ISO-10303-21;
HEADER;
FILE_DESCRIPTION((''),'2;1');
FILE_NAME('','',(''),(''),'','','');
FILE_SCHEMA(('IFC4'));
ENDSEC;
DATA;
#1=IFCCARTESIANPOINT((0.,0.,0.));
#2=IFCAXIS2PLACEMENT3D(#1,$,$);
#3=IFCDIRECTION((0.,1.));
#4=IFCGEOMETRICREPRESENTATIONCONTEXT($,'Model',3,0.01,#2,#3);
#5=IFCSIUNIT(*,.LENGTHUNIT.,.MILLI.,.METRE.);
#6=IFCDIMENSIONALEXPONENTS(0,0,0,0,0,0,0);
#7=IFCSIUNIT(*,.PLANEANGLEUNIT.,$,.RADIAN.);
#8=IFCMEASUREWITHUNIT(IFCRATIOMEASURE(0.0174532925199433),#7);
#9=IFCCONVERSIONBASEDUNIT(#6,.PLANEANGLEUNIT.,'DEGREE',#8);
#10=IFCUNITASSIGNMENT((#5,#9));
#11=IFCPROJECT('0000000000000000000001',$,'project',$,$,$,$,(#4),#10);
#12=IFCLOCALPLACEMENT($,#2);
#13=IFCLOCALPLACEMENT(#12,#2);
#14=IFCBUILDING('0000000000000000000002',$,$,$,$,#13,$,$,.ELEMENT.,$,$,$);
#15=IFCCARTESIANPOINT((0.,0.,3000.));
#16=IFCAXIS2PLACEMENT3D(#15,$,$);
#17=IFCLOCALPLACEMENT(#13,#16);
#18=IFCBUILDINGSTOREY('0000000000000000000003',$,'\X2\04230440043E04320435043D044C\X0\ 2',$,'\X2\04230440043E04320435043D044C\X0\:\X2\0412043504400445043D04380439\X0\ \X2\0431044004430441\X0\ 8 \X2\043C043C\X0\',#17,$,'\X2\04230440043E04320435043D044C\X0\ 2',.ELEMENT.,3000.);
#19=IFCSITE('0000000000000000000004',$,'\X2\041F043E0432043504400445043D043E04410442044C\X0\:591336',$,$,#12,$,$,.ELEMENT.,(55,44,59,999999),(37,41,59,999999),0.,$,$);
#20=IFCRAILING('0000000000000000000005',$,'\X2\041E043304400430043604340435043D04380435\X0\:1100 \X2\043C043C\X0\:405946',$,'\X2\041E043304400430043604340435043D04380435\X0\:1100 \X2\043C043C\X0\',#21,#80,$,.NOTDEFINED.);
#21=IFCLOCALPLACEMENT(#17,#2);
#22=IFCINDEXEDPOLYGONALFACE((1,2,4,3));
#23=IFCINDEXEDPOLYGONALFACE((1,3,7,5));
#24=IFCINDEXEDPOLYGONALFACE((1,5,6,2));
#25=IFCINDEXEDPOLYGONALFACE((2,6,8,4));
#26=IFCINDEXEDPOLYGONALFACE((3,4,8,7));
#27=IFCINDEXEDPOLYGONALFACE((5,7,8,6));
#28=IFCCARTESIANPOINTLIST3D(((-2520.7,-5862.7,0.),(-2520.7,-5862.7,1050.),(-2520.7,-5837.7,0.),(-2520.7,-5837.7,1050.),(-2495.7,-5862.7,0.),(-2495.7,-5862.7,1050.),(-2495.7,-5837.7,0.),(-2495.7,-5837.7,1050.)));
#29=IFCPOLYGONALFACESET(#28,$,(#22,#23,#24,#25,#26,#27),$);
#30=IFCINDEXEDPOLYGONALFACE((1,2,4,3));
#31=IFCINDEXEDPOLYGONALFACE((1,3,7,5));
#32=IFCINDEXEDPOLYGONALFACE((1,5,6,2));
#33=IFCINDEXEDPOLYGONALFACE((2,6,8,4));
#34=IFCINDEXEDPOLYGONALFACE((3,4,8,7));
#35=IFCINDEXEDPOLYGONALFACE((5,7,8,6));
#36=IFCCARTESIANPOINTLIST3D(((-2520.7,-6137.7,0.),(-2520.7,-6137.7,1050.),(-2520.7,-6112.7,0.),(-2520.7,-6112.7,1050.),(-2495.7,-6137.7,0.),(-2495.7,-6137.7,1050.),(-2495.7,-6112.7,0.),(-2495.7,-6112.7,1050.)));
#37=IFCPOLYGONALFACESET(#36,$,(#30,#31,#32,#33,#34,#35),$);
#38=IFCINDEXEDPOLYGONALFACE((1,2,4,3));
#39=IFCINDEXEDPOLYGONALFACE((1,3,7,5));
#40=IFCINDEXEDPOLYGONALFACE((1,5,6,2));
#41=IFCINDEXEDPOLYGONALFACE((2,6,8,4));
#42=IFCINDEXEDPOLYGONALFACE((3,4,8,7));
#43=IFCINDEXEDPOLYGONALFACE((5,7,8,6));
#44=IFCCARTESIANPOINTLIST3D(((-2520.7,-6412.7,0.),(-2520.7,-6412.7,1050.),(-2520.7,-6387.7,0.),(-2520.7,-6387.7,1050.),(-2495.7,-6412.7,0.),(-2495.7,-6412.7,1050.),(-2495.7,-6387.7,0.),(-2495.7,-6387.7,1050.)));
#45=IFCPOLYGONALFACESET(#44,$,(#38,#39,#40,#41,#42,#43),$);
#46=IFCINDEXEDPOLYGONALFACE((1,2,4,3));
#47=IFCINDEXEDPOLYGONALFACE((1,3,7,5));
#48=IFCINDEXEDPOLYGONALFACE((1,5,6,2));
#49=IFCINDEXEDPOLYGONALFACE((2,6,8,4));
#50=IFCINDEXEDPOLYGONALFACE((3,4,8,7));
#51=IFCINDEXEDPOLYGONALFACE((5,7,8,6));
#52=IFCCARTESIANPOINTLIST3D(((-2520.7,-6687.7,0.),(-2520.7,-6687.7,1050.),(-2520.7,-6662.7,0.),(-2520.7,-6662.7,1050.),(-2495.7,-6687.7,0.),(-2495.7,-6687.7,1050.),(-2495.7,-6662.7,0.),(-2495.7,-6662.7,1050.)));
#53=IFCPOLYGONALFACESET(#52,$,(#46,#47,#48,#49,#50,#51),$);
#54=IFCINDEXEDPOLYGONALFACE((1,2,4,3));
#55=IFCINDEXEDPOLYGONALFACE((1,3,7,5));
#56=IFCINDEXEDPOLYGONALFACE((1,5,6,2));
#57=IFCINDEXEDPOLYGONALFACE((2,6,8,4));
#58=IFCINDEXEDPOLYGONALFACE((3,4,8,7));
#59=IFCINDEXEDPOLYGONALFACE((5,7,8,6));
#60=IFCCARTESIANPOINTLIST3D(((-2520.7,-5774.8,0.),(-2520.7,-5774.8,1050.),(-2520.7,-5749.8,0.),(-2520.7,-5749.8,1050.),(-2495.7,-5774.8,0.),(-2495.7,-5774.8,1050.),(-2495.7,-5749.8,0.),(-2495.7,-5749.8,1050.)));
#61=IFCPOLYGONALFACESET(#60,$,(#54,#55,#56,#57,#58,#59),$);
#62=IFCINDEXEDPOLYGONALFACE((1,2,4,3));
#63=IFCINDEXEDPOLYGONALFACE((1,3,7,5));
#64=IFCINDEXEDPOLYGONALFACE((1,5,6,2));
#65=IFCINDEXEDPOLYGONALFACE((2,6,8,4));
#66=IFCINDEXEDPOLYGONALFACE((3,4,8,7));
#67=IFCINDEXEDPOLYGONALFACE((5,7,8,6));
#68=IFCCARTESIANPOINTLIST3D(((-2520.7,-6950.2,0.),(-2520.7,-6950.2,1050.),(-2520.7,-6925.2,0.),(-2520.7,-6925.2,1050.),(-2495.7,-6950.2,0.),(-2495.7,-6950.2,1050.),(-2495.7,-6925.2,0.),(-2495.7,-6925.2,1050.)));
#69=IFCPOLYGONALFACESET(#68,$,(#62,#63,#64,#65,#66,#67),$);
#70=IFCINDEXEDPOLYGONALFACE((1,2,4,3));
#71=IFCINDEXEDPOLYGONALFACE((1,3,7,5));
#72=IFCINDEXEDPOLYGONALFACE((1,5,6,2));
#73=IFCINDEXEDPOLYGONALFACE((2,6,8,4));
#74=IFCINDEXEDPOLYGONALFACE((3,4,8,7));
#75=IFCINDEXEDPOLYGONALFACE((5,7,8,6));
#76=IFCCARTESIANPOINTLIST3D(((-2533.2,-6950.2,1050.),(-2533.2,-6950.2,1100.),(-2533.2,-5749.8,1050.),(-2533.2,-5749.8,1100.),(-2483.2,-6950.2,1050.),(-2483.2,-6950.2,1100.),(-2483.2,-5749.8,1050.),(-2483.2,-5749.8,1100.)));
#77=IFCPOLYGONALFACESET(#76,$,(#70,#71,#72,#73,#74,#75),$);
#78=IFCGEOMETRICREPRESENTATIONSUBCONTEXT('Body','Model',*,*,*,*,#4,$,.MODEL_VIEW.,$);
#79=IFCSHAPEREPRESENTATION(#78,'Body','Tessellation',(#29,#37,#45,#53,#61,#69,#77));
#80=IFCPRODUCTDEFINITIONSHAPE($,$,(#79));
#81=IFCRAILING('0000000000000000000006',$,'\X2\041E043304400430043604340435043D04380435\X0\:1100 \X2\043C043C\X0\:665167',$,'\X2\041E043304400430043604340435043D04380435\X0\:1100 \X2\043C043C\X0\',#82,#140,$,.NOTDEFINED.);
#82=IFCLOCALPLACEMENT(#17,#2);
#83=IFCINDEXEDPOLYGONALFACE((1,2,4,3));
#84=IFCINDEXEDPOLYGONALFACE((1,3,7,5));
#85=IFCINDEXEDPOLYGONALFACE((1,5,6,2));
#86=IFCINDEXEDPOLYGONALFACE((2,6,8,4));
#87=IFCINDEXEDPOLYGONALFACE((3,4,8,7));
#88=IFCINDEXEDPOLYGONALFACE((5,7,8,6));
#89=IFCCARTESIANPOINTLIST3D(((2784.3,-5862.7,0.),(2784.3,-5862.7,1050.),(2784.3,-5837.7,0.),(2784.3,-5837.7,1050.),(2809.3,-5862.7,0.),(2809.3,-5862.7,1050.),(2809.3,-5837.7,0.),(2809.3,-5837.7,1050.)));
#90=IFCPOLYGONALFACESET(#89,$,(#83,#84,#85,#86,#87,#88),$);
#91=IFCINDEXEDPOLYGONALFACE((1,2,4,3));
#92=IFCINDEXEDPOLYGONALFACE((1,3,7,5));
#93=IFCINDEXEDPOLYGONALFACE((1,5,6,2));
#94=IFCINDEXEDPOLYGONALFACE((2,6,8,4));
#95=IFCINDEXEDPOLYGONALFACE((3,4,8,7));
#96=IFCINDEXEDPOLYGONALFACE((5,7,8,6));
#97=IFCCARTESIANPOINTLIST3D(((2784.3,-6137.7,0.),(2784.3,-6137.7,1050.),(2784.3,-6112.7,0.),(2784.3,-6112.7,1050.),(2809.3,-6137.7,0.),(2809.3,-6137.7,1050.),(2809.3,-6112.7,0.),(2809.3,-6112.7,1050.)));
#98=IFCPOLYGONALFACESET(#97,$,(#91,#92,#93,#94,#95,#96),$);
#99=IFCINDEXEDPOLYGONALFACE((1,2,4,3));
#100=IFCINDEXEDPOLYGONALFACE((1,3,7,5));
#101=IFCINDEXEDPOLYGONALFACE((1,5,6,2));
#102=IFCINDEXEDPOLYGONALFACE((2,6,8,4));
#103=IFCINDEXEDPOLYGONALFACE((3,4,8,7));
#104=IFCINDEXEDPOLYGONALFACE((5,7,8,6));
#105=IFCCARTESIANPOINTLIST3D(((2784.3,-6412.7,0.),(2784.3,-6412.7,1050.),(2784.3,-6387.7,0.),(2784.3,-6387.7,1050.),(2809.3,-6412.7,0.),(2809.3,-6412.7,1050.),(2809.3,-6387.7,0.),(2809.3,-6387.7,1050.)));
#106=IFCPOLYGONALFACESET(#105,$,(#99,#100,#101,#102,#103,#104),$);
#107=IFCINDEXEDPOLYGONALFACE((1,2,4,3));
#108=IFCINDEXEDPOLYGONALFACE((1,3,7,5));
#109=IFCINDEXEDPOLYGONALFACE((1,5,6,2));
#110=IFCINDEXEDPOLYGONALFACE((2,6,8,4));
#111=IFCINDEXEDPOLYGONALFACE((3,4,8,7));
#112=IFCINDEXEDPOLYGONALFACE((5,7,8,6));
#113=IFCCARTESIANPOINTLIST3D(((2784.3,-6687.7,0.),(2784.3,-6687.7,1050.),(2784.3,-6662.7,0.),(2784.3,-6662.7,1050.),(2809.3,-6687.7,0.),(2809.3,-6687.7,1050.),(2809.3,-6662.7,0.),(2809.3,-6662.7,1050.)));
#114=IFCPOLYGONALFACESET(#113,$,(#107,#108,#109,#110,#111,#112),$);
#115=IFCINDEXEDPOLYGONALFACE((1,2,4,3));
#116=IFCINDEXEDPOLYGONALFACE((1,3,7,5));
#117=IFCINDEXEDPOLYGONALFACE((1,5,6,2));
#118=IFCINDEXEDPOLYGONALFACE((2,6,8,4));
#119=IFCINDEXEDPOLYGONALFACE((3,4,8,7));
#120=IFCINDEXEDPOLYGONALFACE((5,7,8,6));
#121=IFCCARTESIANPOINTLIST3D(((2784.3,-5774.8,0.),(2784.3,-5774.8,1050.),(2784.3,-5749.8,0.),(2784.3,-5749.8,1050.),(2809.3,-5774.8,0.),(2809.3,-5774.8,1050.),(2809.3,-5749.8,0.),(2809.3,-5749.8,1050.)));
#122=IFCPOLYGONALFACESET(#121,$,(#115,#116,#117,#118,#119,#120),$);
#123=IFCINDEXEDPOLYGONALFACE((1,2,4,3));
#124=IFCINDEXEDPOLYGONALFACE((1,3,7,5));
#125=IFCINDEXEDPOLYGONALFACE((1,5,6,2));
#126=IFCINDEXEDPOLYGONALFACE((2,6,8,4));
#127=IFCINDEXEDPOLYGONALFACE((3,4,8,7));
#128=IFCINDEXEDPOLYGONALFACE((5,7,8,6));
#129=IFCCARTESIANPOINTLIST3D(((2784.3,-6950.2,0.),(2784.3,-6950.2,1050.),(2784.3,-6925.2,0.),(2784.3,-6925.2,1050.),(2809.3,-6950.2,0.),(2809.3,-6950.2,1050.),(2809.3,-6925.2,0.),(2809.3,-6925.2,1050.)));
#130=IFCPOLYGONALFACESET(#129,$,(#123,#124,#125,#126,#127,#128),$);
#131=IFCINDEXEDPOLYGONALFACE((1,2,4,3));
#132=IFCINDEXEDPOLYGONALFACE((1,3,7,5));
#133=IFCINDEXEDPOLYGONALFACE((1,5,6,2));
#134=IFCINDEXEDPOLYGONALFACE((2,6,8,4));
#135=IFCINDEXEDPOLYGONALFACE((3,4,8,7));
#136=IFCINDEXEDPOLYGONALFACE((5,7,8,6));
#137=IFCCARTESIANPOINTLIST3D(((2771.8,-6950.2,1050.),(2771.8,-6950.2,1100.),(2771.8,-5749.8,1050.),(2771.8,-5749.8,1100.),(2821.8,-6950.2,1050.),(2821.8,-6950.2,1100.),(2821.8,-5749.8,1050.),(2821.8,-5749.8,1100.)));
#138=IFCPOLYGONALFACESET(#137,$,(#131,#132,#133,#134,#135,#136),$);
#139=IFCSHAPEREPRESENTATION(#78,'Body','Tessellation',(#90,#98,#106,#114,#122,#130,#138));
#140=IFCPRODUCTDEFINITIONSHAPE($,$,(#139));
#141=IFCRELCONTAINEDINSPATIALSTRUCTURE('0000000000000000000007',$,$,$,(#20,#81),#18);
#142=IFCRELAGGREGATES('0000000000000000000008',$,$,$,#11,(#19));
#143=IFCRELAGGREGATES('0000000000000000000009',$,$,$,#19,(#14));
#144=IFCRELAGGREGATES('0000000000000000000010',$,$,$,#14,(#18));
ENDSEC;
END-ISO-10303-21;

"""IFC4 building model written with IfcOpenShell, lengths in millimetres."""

from ifc_helpers import new_model, entity, si_unit, converted_unit, direction, frame, origin, place, context, subcontext, project, spatial, indexed_curve, outline, extrude, element, save


model = new_model("IFC4")

# Units and contexts
model_context = context("Model", 3, precision=0.01, world=origin(), true_north=direction((0.0, 1.0)))
body_context = subcontext(model_context, "Body", "Model", "MODEL_VIEW")
ifc_project = project(units=[si_unit("LENGTHUNIT", "METRE", prefix="MILLI"), converted_unit("PLANEANGLEUNIT", "DEGREE", entity("IfcRatioMeasure", 0.0174532925199433), si_unit("PLANEANGLEUNIT", "RADIAN"), dimensions=[0, 0, 0, 0, 0, 0, 0])], contexts=[model_context])

# Site, building, storey
site_placement = place(None, origin())
site = spatial("IfcSite", under=ifc_project, at=site_placement, Name="Поверхность:591336", CompositionType="ELEMENT", RefLatitude=(55, 44, 59, 999999), RefLongitude=(37, 41, 59, 999999), RefElevation=0.0)
building_placement = place(site_placement, origin())
building = spatial("IfcBuilding", under=site, at=building_placement, CompositionType="ELEMENT")
storey_placement = place(building_placement, frame((0.0, 0.0, 3000.0)))
storey = spatial("IfcBuildingStorey", under=building, at=storey_placement, Name="Уровень 2", ObjectType="Уровень:Верхний брус 8 мм", LongName="Уровень 2", CompositionType="ELEMENT", Elevation=3000.0)

# Railings
railing_1_placement = place(storey_placement, origin())
element("IfcRailing", 1, at=railing_1_placement, inside=storey, Name="Ограждение:1100 мм:405946", ObjectType="Ограждение:1100 мм", PredefinedType="NOTDEFINED", context=body_context, shape_type="SweptSolid", body=[
    extrude(outline(indexed_curve([(-12.5, -12.5), (12.5, -12.5), (12.5, 12.5), (-12.5, 12.5), (-12.5, -12.5)], self_intersect=False)), frame((-2508.2, -5850.2, 0.0), z_axis=(0.0, 0.0, 1.0), x_axis=(0.0, 1.0, 0.0)), (0.0, 0.0, 1.0), 1050.0),
    extrude(outline(indexed_curve([(-12.5, -12.5), (12.5, -12.5), (12.5, 12.5), (-12.5, 12.5), (-12.5, -12.5)], self_intersect=False)), frame((-2508.2, -6125.2, 0.0), z_axis=(0.0, 0.0, 1.0), x_axis=(0.0, 1.0, 0.0)), (0.0, 0.0, 1.0), 1050.0),
    extrude(outline(indexed_curve([(-12.5, -12.5), (12.5, -12.5), (12.5, 12.5), (-12.5, 12.5), (-12.5, -12.5)], self_intersect=False)), frame((-2508.2, -6400.2, 0.0), z_axis=(0.0, 0.0, 1.0), x_axis=(0.0, 1.0, 0.0)), (0.0, 0.0, 1.0), 1050.0),
    extrude(outline(indexed_curve([(-12.5, -12.5), (12.5, -12.5), (12.5, 12.5), (-12.5, 12.5), (-12.5, -12.5)], self_intersect=False)), frame((-2508.2, -6675.2, 0.0), z_axis=(0.0, 0.0, 1.0), x_axis=(0.0, 1.0, 0.0)), (0.0, 0.0, 1.0), 1050.0),
    extrude(outline(indexed_curve([(-12.5, -12.5), (12.5, -12.5), (12.5, 12.5), (-12.5, 12.5), (-12.5, -12.5)], self_intersect=False)), frame((-2508.2, -5762.3, 0.0), z_axis=(0.0, 0.0, 1.0), x_axis=(0.0, 1.0, 0.0)), (0.0, 0.0, 1.0), 1050.0),
    extrude(outline(indexed_curve([(-12.5, -12.5), (12.5, -12.5), (12.5, 12.5), (-12.5, 12.5), (-12.5, -12.5)], self_intersect=False)), frame((-2508.2, -6937.7, 0.0), z_axis=(0.0, 0.0, 1.0), x_axis=(0.0, 1.0, 0.0)), (0.0, 0.0, 1.0), 1050.0),
    extrude(outline(indexed_curve([(-600.2, -25.0), (600.2, -25.0), (600.2, 25.0), (-600.2, 25.0), (-600.2, -25.0)], self_intersect=False)), frame((-2508.2, -6350.0, 1050.0), z_axis=(0.0, 0.0, 1.0), x_axis=(0.0, 1.0, 0.0)), (0.0, 0.0, 1.0), 50.0),
])
railing_2_placement = place(storey_placement, origin())
element("IfcRailing", 2, at=railing_2_placement, inside=storey, Name="Ограждение:1100 мм:665167", ObjectType="Ограждение:1100 мм", PredefinedType="NOTDEFINED", context=body_context, shape_type="SweptSolid", body=[
    extrude(outline(indexed_curve([(-12.5, -12.5), (12.5, -12.5), (12.5, 12.5), (-12.5, 12.5), (-12.5, -12.5)], self_intersect=False)), frame((2796.8, -5850.2, 0.0)), (0.0, 0.0, 1.0), 1050.0),
    extrude(outline(indexed_curve([(-12.5, -12.5), (12.5, -12.5), (12.5, 12.5), (-12.5, 12.5), (-12.5, -12.5)], self_intersect=False)), frame((2796.8, -6125.2, 0.0)), (0.0, 0.0, 1.0), 1050.0),
    extrude(outline(indexed_curve([(-12.5, -12.5), (12.5, -12.5), (12.5, 12.5), (-12.5, 12.5), (-12.5, -12.5)], self_intersect=False)), frame((2796.8, -6400.2, 0.0)), (0.0, 0.0, 1.0), 1050.0),
    extrude(outline(indexed_curve([(-12.5, -12.5), (12.5, -12.5), (12.5, 12.5), (-12.5, 12.5), (-12.5, -12.5)], self_intersect=False)), frame((2796.8, -6675.2, 0.0)), (0.0, 0.0, 1.0), 1050.0),
    extrude(outline(indexed_curve([(-12.5, -12.5), (12.5, -12.5), (12.5, 12.5), (-12.5, 12.5), (-12.5, -12.5)], self_intersect=False)), frame((2796.8, -5762.3, 0.0)), (0.0, 0.0, 1.0), 1050.0),
    extrude(outline(indexed_curve([(-12.5, -12.5), (12.5, -12.5), (12.5, 12.5), (-12.5, 12.5), (-12.5, -12.5)], self_intersect=False)), frame((2796.8, -6937.7, 0.0)), (0.0, 0.0, 1.0), 1050.0),
    extrude(outline(indexed_curve([(-600.2, -25.0), (600.2, -25.0), (600.2, 25.0), (-600.2, 25.0), (-600.2, -25.0)], self_intersect=False)), frame((2796.8, -6350.0, 1050.0), z_axis=(0.0, 0.0, 1.0), x_axis=(0.0, 1.0, 0.0)), (0.0, 0.0, 1.0), 50.0),
])

save(model, "model.ifc")
